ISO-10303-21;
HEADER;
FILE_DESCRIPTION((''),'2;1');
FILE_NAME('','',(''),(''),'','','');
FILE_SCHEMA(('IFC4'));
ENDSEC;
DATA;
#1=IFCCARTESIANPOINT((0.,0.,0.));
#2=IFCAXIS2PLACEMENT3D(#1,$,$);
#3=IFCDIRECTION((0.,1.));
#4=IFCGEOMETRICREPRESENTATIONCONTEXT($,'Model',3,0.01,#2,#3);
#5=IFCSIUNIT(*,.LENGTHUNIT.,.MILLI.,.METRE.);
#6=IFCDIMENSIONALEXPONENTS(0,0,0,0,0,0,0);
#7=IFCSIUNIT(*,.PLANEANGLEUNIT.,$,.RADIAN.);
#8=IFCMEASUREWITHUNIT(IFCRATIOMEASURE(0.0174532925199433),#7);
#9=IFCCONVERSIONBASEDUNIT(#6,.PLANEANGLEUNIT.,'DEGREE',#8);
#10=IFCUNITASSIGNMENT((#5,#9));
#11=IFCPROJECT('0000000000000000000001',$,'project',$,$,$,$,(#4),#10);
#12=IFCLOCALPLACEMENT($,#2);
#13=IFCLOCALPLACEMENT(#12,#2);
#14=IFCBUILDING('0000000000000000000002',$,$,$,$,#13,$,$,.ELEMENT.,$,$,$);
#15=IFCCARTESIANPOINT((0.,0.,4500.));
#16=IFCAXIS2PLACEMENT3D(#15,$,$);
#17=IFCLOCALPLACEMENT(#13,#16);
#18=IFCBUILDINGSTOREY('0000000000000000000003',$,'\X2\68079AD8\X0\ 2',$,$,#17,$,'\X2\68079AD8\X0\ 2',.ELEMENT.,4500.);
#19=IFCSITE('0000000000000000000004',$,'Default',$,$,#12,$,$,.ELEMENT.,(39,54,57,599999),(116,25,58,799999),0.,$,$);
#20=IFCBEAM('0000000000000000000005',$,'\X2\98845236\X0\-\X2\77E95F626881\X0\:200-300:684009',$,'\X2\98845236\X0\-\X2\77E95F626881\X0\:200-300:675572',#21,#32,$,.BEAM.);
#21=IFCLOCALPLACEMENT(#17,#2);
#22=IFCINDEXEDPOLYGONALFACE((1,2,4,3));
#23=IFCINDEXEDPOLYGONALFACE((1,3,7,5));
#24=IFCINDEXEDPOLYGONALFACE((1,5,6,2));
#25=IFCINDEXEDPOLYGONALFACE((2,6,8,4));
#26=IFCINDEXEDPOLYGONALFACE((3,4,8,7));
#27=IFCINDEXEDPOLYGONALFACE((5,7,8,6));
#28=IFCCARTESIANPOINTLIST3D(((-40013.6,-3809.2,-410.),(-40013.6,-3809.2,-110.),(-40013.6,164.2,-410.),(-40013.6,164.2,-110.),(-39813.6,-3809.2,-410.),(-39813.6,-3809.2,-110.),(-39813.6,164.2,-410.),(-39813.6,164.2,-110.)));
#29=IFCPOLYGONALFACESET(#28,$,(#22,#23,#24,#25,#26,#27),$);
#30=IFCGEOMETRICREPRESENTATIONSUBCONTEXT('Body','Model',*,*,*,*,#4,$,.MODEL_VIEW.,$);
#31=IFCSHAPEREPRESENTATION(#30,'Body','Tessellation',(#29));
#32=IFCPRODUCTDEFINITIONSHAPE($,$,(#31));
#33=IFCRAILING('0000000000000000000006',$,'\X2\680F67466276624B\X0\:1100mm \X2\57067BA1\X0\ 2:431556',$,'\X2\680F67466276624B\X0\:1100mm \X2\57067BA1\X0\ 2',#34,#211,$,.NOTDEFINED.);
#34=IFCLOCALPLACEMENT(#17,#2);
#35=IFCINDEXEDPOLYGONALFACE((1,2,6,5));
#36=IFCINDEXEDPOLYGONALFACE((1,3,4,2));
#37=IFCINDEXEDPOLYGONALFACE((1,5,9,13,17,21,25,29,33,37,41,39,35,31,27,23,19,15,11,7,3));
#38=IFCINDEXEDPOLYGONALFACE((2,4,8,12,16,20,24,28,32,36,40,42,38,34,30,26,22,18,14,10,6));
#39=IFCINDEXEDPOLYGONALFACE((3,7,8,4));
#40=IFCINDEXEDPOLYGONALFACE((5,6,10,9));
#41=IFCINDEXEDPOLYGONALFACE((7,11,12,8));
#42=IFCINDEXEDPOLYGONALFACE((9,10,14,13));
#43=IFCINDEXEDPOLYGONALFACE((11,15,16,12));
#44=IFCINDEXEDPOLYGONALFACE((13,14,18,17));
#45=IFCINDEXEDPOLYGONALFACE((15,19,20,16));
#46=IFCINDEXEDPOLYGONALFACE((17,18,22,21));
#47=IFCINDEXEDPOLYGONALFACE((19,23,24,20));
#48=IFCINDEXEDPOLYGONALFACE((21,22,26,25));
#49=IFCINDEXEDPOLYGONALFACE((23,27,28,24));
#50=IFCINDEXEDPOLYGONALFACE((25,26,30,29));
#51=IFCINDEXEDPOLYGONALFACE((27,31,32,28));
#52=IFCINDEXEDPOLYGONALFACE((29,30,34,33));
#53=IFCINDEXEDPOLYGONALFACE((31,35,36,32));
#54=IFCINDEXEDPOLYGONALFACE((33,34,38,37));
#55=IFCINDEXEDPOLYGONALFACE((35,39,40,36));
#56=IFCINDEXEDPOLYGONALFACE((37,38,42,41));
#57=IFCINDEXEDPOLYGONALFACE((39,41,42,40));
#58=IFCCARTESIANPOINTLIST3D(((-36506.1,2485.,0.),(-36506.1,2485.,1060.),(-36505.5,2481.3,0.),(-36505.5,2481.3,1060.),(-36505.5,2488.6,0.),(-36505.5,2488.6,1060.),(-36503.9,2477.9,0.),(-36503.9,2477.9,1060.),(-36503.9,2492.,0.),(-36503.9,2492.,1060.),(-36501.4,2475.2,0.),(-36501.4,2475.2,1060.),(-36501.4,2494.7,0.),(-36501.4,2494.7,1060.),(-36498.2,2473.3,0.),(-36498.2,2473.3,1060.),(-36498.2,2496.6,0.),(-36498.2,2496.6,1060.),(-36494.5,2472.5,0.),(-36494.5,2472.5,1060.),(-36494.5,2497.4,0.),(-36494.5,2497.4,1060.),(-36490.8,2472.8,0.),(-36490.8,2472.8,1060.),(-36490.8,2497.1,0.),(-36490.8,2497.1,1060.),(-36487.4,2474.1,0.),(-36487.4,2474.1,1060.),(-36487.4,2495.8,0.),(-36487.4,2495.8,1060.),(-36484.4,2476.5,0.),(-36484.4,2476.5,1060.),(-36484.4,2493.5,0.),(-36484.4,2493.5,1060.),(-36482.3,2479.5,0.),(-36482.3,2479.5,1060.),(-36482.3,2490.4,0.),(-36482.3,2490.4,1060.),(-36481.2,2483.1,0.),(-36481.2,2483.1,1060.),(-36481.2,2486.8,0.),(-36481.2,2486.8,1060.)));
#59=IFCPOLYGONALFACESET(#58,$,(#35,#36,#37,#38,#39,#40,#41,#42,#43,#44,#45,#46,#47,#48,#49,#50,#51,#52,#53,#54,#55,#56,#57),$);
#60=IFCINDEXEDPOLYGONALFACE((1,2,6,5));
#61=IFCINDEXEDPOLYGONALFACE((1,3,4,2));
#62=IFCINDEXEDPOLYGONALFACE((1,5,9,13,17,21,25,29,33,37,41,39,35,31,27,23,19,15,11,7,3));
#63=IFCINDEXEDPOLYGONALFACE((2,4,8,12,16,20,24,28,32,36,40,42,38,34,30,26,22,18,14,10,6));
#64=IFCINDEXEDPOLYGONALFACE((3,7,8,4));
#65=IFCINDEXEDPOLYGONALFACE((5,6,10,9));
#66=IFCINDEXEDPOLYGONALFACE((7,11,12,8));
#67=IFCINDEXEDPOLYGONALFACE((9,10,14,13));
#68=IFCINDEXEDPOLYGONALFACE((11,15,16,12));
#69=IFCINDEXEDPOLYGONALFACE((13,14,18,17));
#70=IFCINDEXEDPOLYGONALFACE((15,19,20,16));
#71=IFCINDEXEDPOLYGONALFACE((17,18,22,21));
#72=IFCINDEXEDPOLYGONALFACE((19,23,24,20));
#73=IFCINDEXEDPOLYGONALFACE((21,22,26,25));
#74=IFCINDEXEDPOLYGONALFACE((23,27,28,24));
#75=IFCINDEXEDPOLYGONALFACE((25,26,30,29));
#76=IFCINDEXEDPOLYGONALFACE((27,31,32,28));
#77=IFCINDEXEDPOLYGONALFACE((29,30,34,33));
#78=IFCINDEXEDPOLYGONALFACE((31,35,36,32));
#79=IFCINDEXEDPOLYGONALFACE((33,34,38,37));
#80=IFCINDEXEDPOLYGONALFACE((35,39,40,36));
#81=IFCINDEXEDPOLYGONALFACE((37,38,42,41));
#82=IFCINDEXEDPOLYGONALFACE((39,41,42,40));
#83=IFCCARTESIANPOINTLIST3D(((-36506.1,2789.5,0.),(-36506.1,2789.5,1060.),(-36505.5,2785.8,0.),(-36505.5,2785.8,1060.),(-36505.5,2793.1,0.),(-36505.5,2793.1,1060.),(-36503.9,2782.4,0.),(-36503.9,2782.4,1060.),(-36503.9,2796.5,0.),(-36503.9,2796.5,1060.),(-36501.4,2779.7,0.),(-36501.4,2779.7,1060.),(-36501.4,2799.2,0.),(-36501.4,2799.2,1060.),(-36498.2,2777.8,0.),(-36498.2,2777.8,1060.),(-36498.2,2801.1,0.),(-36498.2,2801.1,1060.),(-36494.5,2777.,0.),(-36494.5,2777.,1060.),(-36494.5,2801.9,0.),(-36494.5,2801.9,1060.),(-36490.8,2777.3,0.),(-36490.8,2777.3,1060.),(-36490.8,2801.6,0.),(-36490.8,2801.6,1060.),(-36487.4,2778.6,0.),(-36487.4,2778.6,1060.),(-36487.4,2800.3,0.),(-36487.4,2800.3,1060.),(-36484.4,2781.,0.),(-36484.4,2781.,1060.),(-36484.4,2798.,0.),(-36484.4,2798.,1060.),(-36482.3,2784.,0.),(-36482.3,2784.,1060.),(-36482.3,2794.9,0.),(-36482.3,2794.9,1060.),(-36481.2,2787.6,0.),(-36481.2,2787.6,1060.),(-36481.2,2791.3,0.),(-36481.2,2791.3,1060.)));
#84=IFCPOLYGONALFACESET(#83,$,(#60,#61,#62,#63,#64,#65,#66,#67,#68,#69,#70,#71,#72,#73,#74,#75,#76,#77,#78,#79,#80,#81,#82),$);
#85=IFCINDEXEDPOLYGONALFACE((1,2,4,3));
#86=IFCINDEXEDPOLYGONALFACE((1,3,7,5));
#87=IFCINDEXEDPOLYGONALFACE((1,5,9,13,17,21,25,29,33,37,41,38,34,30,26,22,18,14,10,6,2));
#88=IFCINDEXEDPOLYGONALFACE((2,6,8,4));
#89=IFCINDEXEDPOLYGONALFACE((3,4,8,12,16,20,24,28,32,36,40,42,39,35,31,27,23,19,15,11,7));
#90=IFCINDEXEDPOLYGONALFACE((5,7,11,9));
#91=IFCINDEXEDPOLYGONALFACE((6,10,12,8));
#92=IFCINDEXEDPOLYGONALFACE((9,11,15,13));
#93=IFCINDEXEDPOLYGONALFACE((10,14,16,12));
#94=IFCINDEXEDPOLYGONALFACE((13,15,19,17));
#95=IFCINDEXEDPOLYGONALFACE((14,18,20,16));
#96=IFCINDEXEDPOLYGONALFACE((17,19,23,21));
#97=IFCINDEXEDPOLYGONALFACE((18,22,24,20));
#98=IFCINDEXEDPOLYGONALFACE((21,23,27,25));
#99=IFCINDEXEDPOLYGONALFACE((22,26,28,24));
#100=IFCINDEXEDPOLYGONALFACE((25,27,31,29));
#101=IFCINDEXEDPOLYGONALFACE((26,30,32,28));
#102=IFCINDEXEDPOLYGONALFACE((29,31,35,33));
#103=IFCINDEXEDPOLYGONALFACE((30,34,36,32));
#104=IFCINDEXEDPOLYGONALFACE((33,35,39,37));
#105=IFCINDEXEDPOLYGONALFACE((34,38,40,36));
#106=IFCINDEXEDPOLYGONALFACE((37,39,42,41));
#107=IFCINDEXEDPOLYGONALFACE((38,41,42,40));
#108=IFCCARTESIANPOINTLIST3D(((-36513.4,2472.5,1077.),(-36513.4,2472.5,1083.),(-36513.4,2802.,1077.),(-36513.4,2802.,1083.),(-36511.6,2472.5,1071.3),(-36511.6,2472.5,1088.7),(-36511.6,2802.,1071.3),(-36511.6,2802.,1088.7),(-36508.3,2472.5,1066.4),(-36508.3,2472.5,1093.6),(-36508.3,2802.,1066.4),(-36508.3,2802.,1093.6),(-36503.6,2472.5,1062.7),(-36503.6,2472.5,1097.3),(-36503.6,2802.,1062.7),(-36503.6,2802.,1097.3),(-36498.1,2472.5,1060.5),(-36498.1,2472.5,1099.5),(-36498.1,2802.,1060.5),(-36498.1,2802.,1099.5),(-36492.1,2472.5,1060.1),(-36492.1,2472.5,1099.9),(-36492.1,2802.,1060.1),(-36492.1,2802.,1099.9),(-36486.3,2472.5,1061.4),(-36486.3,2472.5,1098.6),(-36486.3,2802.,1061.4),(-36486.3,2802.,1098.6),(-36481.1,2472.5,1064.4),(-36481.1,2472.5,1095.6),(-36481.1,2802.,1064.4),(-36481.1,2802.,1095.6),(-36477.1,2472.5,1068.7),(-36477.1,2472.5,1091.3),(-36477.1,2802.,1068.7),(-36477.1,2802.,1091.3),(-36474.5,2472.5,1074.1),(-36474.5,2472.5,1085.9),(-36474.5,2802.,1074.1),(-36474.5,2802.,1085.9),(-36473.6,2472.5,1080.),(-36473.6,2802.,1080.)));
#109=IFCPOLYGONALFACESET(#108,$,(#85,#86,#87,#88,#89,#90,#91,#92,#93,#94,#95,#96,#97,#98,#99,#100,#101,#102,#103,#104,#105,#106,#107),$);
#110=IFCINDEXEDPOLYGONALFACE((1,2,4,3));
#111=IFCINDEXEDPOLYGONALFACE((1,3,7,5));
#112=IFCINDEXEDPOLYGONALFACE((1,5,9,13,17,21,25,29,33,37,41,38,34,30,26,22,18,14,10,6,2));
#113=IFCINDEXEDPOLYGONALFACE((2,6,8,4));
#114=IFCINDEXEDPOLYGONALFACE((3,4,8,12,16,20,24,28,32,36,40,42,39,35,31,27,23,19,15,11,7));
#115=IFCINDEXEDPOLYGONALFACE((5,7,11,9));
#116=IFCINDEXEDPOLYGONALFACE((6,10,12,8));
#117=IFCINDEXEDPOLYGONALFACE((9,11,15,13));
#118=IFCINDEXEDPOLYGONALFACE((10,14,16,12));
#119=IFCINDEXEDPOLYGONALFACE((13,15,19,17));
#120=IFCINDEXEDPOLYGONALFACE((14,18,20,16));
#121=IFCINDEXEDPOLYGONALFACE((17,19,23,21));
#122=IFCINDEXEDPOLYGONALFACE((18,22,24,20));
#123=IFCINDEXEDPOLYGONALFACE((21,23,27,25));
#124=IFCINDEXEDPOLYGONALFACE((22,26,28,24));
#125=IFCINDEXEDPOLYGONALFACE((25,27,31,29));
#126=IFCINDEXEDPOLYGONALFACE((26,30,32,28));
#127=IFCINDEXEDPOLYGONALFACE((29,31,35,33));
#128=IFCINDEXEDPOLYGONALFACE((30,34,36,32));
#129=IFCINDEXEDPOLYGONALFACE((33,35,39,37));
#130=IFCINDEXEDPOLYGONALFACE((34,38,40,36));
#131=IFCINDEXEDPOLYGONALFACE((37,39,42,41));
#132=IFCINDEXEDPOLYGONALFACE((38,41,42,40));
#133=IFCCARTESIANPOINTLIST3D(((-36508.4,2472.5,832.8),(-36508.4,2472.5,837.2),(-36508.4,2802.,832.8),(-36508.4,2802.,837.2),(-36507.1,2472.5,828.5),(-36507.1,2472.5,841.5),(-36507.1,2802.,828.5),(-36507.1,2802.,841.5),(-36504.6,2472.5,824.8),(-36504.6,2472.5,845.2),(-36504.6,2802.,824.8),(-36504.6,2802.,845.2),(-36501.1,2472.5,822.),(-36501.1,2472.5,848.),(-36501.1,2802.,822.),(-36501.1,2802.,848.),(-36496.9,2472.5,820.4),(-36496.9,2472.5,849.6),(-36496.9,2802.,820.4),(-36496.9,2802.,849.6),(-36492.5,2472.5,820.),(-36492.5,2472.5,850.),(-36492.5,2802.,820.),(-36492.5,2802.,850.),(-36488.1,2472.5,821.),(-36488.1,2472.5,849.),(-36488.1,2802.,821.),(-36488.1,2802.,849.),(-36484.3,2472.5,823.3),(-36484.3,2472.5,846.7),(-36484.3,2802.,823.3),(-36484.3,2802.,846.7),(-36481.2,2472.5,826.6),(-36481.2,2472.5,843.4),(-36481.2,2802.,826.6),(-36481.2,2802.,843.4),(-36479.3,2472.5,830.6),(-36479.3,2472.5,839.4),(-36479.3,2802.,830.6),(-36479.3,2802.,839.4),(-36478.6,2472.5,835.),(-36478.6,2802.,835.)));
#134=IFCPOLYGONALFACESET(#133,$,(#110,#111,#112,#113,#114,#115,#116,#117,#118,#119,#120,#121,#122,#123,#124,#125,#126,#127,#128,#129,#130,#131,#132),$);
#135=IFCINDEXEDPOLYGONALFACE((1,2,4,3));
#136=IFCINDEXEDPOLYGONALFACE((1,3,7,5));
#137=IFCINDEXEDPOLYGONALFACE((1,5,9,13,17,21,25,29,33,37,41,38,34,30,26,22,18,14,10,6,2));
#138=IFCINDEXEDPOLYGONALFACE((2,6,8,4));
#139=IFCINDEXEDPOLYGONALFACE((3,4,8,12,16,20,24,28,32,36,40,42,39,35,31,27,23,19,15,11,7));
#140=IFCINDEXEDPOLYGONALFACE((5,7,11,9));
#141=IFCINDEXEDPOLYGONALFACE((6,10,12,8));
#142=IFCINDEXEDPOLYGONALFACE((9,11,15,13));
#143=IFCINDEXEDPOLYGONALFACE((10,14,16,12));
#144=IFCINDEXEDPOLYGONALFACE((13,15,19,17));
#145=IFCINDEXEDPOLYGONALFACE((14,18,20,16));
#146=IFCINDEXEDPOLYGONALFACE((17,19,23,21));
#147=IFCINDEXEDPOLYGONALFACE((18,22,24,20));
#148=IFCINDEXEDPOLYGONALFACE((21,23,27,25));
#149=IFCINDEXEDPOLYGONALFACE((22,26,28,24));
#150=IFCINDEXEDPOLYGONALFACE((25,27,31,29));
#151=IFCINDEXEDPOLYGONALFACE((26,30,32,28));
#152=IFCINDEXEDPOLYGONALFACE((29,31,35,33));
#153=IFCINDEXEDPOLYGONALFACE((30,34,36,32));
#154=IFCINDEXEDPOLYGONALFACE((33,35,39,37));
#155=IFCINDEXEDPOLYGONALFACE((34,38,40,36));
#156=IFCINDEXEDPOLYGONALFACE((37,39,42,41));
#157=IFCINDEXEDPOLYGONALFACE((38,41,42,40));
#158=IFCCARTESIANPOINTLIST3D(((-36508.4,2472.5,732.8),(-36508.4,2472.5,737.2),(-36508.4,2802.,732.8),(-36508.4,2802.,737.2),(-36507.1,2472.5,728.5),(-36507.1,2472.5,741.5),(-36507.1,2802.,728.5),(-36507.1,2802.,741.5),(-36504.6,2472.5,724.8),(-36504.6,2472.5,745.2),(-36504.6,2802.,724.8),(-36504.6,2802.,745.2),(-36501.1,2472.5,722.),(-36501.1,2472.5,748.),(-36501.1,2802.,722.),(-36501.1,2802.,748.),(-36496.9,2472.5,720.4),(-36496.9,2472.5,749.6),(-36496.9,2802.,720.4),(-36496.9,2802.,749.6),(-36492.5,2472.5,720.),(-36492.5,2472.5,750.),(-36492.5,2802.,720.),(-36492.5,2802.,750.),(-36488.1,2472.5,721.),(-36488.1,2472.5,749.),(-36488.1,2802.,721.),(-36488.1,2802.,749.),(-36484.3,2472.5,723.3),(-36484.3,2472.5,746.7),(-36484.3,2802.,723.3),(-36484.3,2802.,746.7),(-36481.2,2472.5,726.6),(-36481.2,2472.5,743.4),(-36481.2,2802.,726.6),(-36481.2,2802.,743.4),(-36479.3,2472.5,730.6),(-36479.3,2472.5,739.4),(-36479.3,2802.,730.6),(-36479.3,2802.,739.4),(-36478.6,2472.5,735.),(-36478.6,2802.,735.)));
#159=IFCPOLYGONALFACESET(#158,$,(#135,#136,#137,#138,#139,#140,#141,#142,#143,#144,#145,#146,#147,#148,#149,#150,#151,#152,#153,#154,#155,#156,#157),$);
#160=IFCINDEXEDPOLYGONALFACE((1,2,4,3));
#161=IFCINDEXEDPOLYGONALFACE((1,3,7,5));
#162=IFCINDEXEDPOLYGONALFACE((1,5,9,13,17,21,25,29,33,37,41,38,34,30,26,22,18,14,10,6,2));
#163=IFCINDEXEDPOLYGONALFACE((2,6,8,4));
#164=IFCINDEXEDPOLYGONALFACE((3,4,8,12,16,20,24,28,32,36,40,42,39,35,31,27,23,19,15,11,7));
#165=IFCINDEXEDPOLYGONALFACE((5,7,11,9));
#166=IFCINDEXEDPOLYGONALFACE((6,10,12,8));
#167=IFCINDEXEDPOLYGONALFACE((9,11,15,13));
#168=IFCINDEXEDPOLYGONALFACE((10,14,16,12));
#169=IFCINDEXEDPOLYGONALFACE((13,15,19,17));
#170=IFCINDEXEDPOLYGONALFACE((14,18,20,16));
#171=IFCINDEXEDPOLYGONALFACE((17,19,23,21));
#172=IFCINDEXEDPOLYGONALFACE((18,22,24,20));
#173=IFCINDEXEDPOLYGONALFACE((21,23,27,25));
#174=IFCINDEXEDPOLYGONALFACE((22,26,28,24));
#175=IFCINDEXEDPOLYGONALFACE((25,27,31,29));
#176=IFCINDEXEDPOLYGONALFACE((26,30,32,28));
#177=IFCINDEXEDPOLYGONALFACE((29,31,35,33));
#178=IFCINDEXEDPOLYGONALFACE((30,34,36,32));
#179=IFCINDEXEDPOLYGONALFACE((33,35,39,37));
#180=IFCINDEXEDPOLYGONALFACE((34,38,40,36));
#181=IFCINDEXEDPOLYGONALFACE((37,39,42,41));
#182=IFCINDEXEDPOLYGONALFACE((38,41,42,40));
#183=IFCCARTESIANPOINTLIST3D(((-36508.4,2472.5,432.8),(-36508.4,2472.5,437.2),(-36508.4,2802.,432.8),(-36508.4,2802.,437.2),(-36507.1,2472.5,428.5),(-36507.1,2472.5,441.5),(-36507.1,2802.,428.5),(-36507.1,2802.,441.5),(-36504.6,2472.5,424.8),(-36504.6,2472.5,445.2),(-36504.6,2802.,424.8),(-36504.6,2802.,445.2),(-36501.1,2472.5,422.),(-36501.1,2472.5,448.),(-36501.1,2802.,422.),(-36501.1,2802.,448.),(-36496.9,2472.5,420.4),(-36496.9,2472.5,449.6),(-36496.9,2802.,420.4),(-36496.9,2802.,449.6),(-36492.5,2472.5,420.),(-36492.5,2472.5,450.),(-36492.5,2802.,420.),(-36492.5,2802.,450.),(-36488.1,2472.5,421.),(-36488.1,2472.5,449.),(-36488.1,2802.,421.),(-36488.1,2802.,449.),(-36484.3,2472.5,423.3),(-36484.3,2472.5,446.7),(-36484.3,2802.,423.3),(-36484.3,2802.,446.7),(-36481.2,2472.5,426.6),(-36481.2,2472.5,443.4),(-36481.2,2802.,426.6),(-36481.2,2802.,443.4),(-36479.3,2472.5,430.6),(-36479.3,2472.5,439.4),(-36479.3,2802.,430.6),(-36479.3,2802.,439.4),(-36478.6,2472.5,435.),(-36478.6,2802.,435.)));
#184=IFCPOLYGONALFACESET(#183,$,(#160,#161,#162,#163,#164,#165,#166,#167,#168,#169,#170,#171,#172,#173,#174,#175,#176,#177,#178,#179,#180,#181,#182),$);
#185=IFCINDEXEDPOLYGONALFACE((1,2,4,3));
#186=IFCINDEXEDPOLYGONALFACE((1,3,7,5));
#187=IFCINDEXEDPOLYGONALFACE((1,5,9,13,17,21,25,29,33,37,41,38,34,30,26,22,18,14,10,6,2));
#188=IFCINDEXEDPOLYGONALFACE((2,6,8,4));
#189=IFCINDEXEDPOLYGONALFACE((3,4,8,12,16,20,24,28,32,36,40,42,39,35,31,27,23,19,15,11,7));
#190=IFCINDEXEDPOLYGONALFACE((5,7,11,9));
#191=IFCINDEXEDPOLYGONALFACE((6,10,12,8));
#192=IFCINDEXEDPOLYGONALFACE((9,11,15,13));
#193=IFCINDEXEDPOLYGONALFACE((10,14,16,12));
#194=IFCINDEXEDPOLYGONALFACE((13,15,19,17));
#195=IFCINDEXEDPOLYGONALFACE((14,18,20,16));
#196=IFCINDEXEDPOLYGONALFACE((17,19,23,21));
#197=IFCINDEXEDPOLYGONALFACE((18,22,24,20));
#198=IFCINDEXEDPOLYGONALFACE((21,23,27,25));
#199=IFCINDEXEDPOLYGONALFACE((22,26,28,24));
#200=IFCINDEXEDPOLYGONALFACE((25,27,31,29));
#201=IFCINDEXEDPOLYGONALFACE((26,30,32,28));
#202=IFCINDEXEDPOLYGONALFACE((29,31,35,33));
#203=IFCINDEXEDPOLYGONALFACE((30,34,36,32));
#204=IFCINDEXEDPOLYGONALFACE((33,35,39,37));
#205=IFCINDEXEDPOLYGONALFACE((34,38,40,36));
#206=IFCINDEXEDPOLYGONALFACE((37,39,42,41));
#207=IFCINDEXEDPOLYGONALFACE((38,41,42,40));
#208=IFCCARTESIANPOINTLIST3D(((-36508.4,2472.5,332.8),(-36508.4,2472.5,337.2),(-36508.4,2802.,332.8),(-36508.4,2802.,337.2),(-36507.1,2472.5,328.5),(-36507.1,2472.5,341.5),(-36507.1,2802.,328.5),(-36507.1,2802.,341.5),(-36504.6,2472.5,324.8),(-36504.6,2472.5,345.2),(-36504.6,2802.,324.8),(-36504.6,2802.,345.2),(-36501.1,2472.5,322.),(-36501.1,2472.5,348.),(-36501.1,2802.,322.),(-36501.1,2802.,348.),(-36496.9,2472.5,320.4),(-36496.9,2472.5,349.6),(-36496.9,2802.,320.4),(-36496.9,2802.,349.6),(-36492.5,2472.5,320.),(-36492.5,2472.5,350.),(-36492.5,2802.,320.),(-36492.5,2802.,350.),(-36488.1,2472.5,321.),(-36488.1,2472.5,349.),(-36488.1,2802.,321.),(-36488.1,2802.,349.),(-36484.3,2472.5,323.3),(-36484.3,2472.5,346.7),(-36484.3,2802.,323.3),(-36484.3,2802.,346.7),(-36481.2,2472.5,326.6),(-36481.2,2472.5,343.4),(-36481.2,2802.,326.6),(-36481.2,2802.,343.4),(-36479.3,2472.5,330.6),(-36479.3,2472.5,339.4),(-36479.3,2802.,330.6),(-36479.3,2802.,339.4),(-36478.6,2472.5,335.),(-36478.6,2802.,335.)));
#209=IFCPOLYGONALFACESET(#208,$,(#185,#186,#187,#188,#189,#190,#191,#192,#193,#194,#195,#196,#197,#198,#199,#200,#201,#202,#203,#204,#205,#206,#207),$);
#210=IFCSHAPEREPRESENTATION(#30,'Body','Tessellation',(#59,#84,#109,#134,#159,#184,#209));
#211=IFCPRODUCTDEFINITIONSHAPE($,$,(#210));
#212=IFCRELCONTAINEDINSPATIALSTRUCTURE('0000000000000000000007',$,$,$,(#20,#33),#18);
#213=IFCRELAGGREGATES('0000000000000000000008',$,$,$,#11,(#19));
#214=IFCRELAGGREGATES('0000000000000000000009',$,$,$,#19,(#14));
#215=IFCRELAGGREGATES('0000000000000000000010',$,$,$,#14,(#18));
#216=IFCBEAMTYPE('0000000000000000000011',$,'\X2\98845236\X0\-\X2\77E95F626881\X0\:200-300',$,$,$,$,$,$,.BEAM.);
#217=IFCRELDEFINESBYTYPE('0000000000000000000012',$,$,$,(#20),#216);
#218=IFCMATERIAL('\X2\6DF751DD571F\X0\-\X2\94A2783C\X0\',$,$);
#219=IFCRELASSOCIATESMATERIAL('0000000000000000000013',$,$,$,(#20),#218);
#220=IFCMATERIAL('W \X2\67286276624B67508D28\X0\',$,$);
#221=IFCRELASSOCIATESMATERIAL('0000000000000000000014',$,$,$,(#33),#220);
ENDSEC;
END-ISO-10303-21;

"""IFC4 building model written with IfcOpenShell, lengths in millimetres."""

from ifc_helpers import new_model, entity, si_unit, converted_unit, direction, frame, frame_2d, origin, origin_2d_with_axis, place, context, subcontext, project, spatial, rectangle, circle, extrude, material, type_object, element, save


model = new_model("IFC4")

# Units and contexts
model_context = context("Model", 3, precision=0.01, world=origin(), true_north=direction((0.0, 1.0)))
body_context = subcontext(model_context, "Body", "Model", "MODEL_VIEW")
ifc_project = project(units=[si_unit("LENGTHUNIT", "METRE", prefix="MILLI"), converted_unit("PLANEANGLEUNIT", "DEGREE", entity("IfcRatioMeasure", 0.0174532925199433), si_unit("PLANEANGLEUNIT", "RADIAN"), dimensions=[0, 0, 0, 0, 0, 0, 0])], contexts=[model_context])

# Site, building, storey
site_placement = place(None, origin())
site = spatial("IfcSite", under=ifc_project, at=site_placement, Name="Default", CompositionType="ELEMENT", RefLatitude=(39, 54, 57, 599999), RefLongitude=(116, 25, 58, 799999), RefElevation=0.0)
building_placement = place(site_placement, origin())
building = spatial("IfcBuilding", under=site, at=building_placement, CompositionType="ELEMENT")
storey_placement = place(building_placement, frame((0.0, 0.0, 4500.0)))
storey = spatial("IfcBuildingStorey", under=building, at=storey_placement, Name="标高 2", LongName="标高 2", CompositionType="ELEMENT", Elevation=4500.0)

# Beam
ifc_material_1 = material(Name="混凝土-钢砼")
beam_type = type_object("IfcBeamType", Name="预制-矩形梁:200-300", PredefinedType="BEAM")
beam_placement = place(storey_placement, frame((-39913.6, 277.5, -110.0), z_axis=(0.0, 0.0, 1.0), x_axis=(0.0, -1.0, 0.0)))
element("IfcBeam", 1, at=beam_placement, inside=storey, type_object=beam_type, material=ifc_material_1, Name="预制-矩形梁:200-300:684009", ObjectType="预制-矩形梁:200-300:675572", PredefinedType="BEAM", context=body_context, shape_type="SweptSolid", body=[
    extrude(rectangle(XDim=300.0, YDim=200.0, at=frame_2d((0.0, 0.0), x_axis=(1.0, 0.0))), frame((113.3, 0.0, -150.0), z_axis=(1.0, 0.0, 0.0), x_axis=(0.0, 0.0, -1.0)), (0.0, 0.0, 1.0), 3973.4),
])

# Railing
ifc_material_2 = material(Name="W 木扶手材质")
railing_placement = place(storey_placement, frame((-36515.2, 2470.9, 0.0)))
element("IfcRailing", 2, at=railing_placement, inside=storey, material=ifc_material_2, Name="栏杆扶手:1100mm 圆管 2:431556", ObjectType="栏杆扶手:1100mm 圆管 2", PredefinedType="NOTDEFINED", context=body_context, shape_type="SweptSolid", body=[
    extrude(circle(Radius=12.5, at=origin_2d_with_axis()), frame((21.6, 14.1, 0.0), z_axis=(0.0, 0.0, 1.0), x_axis=(-1.0, 0.0, 0.0)), (0.0, 0.0, 1.0), 1060.0),
    extrude(circle(Radius=12.5, at=origin_2d_with_axis()), frame((21.6, 318.6, 0.0), z_axis=(0.0, 0.0, 1.0), x_axis=(-1.0, 0.0, 0.0)), (0.0, 0.0, 1.0), 1060.0),
    extrude(circle(Radius=20.0, at=origin_2d_with_axis()), frame((21.6, 1.6, 1080.0), z_axis=(0.0, 1.0, 0.0), x_axis=(1.0, 0.0, 0.0)), (0.0, 0.0, 1.0), 329.5),
    extrude(circle(Radius=15.0, at=origin_2d_with_axis()), frame((21.6, 1.6, 835.0), z_axis=(0.0, 1.0, 0.0), x_axis=(1.0, 0.0, 0.0)), (0.0, 0.0, 1.0), 329.5),
    extrude(circle(Radius=15.0, at=origin_2d_with_axis()), frame((21.6, 1.6, 735.0), z_axis=(0.0, 1.0, 0.0), x_axis=(1.0, 0.0, 0.0)), (0.0, 0.0, 1.0), 329.5),
    extrude(circle(Radius=15.0, at=origin_2d_with_axis()), frame((21.6, 1.6, 435.0), z_axis=(0.0, 1.0, 0.0), x_axis=(1.0, 0.0, 0.0)), (0.0, 0.0, 1.0), 329.5),
    extrude(circle(Radius=15.0, at=origin_2d_with_axis()), frame((21.6, 1.6, 335.0), z_axis=(0.0, 1.0, 0.0), x_axis=(1.0, 0.0, 0.0)), (0.0, 0.0, 1.0), 329.5),
])

save(model, "model.ifc")
